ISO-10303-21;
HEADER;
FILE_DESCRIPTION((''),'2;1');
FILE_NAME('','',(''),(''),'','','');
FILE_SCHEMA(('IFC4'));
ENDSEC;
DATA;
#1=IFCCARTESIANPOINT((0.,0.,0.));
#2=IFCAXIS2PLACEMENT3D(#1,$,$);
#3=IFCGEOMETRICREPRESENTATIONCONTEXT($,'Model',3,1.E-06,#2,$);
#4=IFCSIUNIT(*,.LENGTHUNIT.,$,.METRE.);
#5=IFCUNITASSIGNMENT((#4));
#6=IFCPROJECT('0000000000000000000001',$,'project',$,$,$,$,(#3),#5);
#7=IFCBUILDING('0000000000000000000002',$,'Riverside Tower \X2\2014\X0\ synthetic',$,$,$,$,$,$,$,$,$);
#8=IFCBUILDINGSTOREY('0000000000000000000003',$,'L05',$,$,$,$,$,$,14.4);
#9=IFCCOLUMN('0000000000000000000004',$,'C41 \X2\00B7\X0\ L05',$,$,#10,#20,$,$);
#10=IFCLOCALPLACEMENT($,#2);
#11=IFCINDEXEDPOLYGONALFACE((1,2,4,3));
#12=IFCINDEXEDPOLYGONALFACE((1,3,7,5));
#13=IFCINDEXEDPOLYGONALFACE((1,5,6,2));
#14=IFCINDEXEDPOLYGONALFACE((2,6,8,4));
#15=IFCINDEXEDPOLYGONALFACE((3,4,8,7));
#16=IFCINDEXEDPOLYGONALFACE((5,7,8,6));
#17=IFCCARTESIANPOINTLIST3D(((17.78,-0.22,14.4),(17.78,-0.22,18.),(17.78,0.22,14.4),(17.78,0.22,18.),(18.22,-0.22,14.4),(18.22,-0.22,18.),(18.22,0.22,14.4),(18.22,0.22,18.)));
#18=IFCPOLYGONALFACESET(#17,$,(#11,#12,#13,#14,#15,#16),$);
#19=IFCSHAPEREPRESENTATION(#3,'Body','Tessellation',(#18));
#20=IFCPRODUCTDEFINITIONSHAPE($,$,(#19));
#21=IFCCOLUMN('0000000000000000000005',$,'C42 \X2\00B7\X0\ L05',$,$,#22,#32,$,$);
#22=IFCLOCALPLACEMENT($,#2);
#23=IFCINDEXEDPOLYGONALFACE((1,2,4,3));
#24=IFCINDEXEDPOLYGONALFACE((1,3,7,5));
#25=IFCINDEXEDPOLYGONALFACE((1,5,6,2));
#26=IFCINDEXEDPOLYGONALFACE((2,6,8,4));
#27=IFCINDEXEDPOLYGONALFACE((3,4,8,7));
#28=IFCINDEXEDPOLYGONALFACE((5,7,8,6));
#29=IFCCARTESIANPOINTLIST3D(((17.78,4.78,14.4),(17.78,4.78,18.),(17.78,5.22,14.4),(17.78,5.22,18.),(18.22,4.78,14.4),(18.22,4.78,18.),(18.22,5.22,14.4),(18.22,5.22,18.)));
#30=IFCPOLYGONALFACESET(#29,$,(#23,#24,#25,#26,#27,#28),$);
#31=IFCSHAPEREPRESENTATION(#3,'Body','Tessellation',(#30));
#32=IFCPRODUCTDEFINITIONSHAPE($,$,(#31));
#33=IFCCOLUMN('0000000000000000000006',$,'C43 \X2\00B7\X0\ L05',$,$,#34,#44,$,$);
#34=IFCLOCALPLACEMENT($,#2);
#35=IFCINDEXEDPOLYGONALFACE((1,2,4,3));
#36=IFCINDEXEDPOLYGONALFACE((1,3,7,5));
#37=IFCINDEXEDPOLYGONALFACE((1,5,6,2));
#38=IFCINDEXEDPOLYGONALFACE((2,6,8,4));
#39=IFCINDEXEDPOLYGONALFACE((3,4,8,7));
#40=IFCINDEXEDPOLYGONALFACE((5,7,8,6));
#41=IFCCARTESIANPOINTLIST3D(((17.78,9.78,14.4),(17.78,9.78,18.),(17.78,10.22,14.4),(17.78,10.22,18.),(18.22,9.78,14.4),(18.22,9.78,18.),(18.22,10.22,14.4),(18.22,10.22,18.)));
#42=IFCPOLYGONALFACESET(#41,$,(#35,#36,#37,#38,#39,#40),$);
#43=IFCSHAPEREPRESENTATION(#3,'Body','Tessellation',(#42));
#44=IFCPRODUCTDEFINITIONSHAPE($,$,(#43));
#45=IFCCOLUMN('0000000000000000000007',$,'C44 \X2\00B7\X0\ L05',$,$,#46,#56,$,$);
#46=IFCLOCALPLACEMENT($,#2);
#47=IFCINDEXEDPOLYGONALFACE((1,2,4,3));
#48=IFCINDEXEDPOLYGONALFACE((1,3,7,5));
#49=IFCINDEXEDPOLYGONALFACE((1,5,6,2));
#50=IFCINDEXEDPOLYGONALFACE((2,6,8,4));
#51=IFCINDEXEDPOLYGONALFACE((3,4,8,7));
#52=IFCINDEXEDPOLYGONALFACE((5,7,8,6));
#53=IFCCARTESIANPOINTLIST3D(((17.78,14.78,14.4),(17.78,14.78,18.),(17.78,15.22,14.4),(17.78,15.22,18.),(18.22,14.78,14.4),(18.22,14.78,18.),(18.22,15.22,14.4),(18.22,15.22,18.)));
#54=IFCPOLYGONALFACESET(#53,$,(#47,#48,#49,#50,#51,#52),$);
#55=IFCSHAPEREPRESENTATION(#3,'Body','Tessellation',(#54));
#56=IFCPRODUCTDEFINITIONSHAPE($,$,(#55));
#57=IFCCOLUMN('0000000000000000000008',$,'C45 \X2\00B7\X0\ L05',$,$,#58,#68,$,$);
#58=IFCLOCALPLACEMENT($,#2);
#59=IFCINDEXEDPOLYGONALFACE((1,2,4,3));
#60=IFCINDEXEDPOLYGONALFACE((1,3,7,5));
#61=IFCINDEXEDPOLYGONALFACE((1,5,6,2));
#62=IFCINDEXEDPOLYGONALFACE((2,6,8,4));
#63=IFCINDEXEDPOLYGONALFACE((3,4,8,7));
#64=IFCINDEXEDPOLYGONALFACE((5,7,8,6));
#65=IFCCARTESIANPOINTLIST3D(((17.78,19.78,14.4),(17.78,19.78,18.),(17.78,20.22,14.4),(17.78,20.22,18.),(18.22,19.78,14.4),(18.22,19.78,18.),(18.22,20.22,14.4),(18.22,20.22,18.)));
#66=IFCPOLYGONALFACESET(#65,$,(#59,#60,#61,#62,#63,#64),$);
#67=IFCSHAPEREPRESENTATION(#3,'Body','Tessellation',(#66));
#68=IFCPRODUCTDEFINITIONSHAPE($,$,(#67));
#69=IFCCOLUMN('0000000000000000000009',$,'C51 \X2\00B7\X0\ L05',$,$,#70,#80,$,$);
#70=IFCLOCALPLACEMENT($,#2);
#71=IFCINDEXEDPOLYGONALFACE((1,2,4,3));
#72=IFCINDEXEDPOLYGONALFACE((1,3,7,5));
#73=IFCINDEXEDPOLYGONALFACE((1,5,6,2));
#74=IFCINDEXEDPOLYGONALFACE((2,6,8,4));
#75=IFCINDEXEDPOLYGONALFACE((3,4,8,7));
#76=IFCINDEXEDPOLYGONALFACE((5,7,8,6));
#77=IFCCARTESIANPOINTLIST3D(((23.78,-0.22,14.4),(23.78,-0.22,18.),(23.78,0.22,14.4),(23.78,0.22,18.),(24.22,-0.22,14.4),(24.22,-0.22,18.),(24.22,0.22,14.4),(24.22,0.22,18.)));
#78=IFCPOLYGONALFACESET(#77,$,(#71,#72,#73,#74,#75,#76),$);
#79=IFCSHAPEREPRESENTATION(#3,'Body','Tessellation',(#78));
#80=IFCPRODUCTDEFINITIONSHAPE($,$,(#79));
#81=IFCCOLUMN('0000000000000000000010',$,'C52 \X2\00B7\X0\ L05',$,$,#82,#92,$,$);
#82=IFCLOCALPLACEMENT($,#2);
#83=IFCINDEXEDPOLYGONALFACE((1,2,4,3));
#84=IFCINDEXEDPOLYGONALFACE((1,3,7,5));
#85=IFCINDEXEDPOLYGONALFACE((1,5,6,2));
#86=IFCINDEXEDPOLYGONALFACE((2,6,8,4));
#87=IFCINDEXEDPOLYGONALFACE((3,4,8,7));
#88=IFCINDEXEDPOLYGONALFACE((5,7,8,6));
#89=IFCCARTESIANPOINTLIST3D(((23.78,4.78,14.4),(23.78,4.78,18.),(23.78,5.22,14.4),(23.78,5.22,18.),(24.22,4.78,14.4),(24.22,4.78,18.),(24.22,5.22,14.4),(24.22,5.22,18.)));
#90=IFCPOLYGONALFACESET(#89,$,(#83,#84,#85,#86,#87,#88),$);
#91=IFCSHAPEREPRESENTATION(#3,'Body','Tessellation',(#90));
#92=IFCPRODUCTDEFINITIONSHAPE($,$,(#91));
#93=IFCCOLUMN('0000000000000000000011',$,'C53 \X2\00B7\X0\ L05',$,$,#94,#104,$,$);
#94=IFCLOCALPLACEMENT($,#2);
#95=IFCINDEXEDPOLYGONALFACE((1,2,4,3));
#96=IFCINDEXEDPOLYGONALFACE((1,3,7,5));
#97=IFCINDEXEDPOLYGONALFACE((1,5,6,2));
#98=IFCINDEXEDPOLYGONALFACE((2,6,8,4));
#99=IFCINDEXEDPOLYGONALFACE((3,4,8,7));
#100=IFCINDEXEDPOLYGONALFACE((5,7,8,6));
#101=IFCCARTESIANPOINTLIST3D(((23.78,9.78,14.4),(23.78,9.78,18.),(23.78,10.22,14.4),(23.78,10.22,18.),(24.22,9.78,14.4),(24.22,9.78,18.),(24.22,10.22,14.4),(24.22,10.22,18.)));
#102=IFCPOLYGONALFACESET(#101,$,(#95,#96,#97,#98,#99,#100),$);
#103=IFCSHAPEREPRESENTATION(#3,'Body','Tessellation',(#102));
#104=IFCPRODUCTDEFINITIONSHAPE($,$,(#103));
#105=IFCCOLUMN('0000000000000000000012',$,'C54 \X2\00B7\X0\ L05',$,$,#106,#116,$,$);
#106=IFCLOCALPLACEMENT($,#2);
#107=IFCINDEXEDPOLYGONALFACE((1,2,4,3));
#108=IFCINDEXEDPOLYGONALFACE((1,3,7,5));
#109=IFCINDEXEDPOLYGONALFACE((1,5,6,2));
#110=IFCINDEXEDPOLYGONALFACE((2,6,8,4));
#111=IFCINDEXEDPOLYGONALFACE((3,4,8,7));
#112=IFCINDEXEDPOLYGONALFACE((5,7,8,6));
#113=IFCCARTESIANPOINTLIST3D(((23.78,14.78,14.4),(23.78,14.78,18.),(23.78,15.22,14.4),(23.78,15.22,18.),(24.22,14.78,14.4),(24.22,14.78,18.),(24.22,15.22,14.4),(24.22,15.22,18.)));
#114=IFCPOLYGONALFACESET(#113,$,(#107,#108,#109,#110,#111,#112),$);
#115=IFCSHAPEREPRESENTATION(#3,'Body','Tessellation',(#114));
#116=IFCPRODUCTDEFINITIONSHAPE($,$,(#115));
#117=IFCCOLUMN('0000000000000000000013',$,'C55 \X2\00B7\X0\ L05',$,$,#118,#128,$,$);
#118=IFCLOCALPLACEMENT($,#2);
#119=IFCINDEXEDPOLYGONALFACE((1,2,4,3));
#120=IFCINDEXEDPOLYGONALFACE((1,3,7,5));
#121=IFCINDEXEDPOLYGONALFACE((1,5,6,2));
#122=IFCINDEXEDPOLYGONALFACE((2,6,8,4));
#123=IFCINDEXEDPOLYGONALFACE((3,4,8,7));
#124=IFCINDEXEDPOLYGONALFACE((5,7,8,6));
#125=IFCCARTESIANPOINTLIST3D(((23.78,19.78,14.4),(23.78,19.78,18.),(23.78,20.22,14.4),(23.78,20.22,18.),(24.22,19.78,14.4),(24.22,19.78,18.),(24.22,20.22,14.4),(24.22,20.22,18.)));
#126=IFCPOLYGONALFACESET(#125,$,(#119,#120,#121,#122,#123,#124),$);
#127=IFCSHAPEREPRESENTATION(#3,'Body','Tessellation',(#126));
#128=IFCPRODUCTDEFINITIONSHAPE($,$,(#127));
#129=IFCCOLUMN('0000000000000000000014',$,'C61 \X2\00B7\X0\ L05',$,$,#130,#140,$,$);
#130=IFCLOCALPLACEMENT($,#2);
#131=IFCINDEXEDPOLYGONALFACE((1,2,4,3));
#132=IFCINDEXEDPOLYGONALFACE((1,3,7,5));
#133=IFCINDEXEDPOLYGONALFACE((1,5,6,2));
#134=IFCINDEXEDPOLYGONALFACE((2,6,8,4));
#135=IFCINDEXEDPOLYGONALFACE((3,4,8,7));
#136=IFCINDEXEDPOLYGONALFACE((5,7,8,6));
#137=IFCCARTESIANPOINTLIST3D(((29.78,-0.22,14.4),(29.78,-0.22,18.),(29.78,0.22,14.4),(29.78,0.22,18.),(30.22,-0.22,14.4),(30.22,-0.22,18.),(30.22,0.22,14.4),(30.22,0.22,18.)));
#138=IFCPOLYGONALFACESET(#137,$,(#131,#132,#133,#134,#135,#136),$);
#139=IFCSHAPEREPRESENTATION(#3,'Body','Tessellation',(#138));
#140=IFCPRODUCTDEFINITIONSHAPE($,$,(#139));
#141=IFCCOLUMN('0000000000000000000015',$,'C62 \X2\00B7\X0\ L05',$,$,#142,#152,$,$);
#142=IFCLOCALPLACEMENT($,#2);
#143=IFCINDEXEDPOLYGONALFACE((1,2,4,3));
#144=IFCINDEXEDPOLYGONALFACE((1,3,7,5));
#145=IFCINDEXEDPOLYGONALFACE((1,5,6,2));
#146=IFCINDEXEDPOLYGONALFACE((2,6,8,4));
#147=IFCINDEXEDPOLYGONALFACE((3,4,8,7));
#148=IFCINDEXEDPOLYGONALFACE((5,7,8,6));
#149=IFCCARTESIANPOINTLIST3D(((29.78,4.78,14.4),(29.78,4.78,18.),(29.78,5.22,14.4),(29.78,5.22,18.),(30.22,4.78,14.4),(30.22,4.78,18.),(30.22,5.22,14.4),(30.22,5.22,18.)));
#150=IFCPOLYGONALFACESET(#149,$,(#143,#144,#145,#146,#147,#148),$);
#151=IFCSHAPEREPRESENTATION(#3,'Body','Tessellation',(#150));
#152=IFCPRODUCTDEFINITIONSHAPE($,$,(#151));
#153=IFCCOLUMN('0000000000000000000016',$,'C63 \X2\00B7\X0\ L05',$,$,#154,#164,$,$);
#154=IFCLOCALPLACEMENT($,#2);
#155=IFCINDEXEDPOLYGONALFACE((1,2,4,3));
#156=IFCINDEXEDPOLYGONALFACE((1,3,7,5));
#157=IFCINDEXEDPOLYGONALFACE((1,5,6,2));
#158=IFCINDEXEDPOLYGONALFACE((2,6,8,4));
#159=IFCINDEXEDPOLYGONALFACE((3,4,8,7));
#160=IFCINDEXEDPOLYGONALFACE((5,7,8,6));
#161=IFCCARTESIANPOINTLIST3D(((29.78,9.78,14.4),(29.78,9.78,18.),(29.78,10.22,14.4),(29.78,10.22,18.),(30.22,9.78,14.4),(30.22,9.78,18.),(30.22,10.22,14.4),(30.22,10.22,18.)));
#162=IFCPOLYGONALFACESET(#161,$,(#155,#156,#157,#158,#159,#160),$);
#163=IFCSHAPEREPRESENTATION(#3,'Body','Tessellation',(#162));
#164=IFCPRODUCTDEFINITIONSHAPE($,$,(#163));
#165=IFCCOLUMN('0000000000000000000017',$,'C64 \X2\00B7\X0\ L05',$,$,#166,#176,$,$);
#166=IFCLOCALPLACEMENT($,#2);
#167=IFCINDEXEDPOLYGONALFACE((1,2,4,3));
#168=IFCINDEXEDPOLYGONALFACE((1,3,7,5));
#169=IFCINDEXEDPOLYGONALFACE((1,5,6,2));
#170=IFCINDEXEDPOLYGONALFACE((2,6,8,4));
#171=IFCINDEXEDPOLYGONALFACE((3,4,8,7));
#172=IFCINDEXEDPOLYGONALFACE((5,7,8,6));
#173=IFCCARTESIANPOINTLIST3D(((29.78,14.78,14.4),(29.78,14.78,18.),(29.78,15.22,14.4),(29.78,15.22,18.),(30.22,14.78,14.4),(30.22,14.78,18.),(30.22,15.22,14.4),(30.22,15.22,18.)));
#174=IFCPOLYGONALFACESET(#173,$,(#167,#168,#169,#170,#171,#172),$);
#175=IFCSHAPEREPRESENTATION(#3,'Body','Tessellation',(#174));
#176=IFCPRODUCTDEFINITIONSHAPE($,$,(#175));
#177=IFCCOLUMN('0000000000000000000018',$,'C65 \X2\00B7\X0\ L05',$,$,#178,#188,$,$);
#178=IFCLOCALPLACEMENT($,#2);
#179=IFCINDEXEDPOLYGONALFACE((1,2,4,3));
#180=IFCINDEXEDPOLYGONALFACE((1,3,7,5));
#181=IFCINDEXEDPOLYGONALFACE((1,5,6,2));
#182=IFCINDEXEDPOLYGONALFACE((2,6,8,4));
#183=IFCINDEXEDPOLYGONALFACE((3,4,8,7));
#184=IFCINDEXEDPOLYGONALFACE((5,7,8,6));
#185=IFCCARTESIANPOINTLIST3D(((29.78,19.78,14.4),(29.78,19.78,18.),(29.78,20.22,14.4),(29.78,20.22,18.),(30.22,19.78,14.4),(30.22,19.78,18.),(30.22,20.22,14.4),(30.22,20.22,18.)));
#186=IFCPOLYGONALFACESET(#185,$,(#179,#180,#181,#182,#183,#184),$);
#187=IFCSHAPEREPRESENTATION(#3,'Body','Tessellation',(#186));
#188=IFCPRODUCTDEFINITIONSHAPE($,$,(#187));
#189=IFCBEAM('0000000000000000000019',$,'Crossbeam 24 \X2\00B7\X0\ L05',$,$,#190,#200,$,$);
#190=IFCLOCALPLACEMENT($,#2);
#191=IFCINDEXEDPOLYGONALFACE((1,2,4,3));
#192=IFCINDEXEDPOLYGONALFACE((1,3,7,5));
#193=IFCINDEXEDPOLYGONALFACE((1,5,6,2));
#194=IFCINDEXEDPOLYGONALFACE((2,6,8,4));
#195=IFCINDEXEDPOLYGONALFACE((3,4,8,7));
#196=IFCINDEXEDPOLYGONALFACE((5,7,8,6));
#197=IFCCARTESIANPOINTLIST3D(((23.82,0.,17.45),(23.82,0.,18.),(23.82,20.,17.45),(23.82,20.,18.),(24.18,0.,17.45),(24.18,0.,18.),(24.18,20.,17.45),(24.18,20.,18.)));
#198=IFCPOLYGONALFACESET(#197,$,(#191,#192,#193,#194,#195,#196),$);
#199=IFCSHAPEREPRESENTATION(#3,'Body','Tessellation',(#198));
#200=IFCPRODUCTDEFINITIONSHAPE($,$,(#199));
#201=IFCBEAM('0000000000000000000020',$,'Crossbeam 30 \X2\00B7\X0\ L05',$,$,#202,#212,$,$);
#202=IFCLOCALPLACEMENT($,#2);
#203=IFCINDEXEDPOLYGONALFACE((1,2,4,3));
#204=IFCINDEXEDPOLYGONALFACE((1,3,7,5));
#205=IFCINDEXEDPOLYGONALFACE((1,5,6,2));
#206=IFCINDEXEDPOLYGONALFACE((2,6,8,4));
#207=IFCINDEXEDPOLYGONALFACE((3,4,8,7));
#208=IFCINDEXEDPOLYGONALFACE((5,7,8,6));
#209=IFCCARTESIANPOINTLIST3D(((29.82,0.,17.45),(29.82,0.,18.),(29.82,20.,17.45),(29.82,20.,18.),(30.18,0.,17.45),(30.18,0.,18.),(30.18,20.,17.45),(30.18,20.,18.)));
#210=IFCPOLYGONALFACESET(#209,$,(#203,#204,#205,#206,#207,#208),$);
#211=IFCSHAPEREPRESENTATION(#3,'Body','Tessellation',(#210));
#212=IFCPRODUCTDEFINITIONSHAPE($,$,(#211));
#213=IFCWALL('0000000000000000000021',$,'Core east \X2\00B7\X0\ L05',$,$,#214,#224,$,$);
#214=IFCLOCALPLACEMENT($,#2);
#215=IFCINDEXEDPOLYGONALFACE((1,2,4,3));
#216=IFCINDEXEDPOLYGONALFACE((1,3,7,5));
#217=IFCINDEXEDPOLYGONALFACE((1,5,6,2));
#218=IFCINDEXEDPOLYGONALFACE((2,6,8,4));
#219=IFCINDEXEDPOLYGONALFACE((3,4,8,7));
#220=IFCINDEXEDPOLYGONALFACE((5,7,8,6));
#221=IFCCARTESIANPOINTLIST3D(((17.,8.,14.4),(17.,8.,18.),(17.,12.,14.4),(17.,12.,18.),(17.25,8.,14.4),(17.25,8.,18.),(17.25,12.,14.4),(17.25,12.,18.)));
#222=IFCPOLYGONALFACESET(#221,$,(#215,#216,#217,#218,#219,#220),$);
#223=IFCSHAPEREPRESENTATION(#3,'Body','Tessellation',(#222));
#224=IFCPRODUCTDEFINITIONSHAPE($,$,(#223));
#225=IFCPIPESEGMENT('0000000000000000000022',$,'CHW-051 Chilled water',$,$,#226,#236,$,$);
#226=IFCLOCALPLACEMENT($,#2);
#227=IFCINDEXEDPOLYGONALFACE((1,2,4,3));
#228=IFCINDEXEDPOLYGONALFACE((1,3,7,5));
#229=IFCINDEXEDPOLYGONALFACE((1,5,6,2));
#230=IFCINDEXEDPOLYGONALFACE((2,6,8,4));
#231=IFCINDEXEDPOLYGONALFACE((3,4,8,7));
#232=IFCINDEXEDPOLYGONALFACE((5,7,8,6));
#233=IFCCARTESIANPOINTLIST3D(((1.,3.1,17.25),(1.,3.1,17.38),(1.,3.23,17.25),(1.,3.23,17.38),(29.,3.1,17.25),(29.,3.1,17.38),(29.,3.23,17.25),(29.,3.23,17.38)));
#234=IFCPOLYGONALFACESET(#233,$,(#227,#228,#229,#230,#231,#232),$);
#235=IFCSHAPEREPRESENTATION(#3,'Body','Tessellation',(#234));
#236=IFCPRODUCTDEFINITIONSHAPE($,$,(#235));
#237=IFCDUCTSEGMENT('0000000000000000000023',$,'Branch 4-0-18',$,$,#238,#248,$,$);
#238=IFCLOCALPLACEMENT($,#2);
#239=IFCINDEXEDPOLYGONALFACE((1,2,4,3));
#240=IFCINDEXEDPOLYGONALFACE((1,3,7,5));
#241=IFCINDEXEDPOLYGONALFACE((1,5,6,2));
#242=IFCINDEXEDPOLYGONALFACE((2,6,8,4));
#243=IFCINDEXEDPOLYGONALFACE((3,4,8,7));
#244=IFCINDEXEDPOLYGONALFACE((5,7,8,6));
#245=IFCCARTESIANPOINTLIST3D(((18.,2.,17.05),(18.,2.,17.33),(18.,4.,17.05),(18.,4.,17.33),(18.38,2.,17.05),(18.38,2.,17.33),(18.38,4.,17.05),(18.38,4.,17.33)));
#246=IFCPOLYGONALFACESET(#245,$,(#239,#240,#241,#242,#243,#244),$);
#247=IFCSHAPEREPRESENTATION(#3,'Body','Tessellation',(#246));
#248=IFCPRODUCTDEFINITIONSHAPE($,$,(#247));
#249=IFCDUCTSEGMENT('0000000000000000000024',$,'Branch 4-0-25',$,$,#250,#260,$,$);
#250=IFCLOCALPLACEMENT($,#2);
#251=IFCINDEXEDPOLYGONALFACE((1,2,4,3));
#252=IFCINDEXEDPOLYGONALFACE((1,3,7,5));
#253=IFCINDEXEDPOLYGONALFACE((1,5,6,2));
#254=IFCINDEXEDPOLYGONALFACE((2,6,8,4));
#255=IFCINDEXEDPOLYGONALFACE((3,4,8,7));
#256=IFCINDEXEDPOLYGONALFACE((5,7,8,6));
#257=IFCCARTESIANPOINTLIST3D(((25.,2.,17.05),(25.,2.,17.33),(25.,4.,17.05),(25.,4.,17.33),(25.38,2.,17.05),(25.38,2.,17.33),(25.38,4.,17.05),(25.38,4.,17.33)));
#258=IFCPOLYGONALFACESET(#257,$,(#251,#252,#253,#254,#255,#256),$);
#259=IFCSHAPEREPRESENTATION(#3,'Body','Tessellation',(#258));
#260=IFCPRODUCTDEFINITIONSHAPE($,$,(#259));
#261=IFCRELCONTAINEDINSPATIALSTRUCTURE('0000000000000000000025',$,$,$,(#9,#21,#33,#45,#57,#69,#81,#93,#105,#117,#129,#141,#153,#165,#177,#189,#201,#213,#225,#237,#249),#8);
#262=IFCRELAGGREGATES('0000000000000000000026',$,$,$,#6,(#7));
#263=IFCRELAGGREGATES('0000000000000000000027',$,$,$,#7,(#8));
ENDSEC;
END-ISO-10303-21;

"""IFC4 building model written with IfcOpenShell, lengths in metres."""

from ifc_helpers import new_model, si_unit, frame, origin, place, context, project, spatial, rectangle, extrude, element, save


model = new_model("IFC4")

# Units and contexts
model_context = context("Model", 3, precision=1e-06, world=origin())
ifc_project = project(units=[si_unit("LENGTHUNIT", "METRE")], contexts=[model_context])

# Building, storey
building = spatial("IfcBuilding", under=ifc_project, Name="Riverside Tower — synthetic")
storey = spatial("IfcBuildingStorey", under=building, Name="L05", Elevation=14.4)

# Columns
for number, where, name in (
    (1, (18.0, 0.0, 14.4), "C41 · L05"),
    (2, (18.0, 5.0, 14.4), "C42 · L05"),
    (3, (18.0, 10.0, 14.4), "C43 · L05"),
    (4, (18.0, 15.0, 14.4), "C44 · L05"),
    (5, (18.0, 20.0, 14.4), "C45 · L05"),
    (6, (24.0, 0.0, 14.4), "C51 · L05"),
    (7, (24.0, 5.0, 14.4), "C52 · L05"),
    (8, (24.0, 10.0, 14.4), "C53 · L05"),
    (9, (24.0, 15.0, 14.4), "C54 · L05"),
    (10, (24.0, 20.0, 14.4), "C55 · L05"),
    (11, (30.0, 0.0, 14.4), "C61 · L05"),
    (12, (30.0, 5.0, 14.4), "C62 · L05"),
    (13, (30.0, 10.0, 14.4), "C63 · L05"),
    (14, (30.0, 15.0, 14.4), "C64 · L05"),
    (15, (30.0, 20.0, 14.4), "C65 · L05"),
):
    element("IfcColumn", number, at=place(None, frame(where)), inside=storey, Name=name, context=model_context, shape_type="SweptSolid", body=[
        extrude(rectangle(XDim=0.44, YDim=0.44), origin(), (0.0, 0.0, 1.0), 3.6),
    ])

# Beams
for number, where, name in (
    (16, (24.0, 10.0, 17.45), "Crossbeam 24 · L05"),
    (17, (30.0, 10.0, 17.45), "Crossbeam 30 · L05"),
):
    element("IfcBeam", number, at=place(None, frame(where)), inside=storey, Name=name, context=model_context, shape_type="SweptSolid", body=[
        extrude(rectangle(XDim=0.36, YDim=20.0), origin(), (0.0, 0.0, 1.0), 0.55),
    ])

# Wall
wall_placement = place(None, frame((17.125, 10.0, 14.4)))
element("IfcWall", 18, at=wall_placement, inside=storey, Name="Core east · L05", context=model_context, shape_type="SweptSolid", body=[
    extrude(rectangle(XDim=0.25, YDim=4.0), origin(), (0.0, 0.0, 1.0), 3.6),
])

# Pipe segment
pipe_segment_1_placement = place(None, frame((15.0, 3.165, 17.25)))
element("IfcPipeSegment", 19, at=pipe_segment_1_placement, inside=storey, Name="CHW-051 Chilled water", context=model_context, shape_type="SweptSolid", body=[
    extrude(rectangle(XDim=28.0, YDim=0.13), origin(), (0.0, 0.0, 1.0), 0.13),
])

# Duct segments
for number, where, name in (
    (20, (18.19, 3.0, 17.05), "Branch 4-0-18"),
    (21, (25.19, 3.0, 17.05), "Branch 4-0-25"),
):
    element("IfcDuctSegment", number, at=place(None, frame(where)), inside=storey, Name=name, context=model_context, shape_type="SweptSolid", body=[
        extrude(rectangle(XDim=0.38, YDim=2.0), origin(), (0.0, 0.0, 1.0), 0.28),
    ])

save(model, "model.ifc")
